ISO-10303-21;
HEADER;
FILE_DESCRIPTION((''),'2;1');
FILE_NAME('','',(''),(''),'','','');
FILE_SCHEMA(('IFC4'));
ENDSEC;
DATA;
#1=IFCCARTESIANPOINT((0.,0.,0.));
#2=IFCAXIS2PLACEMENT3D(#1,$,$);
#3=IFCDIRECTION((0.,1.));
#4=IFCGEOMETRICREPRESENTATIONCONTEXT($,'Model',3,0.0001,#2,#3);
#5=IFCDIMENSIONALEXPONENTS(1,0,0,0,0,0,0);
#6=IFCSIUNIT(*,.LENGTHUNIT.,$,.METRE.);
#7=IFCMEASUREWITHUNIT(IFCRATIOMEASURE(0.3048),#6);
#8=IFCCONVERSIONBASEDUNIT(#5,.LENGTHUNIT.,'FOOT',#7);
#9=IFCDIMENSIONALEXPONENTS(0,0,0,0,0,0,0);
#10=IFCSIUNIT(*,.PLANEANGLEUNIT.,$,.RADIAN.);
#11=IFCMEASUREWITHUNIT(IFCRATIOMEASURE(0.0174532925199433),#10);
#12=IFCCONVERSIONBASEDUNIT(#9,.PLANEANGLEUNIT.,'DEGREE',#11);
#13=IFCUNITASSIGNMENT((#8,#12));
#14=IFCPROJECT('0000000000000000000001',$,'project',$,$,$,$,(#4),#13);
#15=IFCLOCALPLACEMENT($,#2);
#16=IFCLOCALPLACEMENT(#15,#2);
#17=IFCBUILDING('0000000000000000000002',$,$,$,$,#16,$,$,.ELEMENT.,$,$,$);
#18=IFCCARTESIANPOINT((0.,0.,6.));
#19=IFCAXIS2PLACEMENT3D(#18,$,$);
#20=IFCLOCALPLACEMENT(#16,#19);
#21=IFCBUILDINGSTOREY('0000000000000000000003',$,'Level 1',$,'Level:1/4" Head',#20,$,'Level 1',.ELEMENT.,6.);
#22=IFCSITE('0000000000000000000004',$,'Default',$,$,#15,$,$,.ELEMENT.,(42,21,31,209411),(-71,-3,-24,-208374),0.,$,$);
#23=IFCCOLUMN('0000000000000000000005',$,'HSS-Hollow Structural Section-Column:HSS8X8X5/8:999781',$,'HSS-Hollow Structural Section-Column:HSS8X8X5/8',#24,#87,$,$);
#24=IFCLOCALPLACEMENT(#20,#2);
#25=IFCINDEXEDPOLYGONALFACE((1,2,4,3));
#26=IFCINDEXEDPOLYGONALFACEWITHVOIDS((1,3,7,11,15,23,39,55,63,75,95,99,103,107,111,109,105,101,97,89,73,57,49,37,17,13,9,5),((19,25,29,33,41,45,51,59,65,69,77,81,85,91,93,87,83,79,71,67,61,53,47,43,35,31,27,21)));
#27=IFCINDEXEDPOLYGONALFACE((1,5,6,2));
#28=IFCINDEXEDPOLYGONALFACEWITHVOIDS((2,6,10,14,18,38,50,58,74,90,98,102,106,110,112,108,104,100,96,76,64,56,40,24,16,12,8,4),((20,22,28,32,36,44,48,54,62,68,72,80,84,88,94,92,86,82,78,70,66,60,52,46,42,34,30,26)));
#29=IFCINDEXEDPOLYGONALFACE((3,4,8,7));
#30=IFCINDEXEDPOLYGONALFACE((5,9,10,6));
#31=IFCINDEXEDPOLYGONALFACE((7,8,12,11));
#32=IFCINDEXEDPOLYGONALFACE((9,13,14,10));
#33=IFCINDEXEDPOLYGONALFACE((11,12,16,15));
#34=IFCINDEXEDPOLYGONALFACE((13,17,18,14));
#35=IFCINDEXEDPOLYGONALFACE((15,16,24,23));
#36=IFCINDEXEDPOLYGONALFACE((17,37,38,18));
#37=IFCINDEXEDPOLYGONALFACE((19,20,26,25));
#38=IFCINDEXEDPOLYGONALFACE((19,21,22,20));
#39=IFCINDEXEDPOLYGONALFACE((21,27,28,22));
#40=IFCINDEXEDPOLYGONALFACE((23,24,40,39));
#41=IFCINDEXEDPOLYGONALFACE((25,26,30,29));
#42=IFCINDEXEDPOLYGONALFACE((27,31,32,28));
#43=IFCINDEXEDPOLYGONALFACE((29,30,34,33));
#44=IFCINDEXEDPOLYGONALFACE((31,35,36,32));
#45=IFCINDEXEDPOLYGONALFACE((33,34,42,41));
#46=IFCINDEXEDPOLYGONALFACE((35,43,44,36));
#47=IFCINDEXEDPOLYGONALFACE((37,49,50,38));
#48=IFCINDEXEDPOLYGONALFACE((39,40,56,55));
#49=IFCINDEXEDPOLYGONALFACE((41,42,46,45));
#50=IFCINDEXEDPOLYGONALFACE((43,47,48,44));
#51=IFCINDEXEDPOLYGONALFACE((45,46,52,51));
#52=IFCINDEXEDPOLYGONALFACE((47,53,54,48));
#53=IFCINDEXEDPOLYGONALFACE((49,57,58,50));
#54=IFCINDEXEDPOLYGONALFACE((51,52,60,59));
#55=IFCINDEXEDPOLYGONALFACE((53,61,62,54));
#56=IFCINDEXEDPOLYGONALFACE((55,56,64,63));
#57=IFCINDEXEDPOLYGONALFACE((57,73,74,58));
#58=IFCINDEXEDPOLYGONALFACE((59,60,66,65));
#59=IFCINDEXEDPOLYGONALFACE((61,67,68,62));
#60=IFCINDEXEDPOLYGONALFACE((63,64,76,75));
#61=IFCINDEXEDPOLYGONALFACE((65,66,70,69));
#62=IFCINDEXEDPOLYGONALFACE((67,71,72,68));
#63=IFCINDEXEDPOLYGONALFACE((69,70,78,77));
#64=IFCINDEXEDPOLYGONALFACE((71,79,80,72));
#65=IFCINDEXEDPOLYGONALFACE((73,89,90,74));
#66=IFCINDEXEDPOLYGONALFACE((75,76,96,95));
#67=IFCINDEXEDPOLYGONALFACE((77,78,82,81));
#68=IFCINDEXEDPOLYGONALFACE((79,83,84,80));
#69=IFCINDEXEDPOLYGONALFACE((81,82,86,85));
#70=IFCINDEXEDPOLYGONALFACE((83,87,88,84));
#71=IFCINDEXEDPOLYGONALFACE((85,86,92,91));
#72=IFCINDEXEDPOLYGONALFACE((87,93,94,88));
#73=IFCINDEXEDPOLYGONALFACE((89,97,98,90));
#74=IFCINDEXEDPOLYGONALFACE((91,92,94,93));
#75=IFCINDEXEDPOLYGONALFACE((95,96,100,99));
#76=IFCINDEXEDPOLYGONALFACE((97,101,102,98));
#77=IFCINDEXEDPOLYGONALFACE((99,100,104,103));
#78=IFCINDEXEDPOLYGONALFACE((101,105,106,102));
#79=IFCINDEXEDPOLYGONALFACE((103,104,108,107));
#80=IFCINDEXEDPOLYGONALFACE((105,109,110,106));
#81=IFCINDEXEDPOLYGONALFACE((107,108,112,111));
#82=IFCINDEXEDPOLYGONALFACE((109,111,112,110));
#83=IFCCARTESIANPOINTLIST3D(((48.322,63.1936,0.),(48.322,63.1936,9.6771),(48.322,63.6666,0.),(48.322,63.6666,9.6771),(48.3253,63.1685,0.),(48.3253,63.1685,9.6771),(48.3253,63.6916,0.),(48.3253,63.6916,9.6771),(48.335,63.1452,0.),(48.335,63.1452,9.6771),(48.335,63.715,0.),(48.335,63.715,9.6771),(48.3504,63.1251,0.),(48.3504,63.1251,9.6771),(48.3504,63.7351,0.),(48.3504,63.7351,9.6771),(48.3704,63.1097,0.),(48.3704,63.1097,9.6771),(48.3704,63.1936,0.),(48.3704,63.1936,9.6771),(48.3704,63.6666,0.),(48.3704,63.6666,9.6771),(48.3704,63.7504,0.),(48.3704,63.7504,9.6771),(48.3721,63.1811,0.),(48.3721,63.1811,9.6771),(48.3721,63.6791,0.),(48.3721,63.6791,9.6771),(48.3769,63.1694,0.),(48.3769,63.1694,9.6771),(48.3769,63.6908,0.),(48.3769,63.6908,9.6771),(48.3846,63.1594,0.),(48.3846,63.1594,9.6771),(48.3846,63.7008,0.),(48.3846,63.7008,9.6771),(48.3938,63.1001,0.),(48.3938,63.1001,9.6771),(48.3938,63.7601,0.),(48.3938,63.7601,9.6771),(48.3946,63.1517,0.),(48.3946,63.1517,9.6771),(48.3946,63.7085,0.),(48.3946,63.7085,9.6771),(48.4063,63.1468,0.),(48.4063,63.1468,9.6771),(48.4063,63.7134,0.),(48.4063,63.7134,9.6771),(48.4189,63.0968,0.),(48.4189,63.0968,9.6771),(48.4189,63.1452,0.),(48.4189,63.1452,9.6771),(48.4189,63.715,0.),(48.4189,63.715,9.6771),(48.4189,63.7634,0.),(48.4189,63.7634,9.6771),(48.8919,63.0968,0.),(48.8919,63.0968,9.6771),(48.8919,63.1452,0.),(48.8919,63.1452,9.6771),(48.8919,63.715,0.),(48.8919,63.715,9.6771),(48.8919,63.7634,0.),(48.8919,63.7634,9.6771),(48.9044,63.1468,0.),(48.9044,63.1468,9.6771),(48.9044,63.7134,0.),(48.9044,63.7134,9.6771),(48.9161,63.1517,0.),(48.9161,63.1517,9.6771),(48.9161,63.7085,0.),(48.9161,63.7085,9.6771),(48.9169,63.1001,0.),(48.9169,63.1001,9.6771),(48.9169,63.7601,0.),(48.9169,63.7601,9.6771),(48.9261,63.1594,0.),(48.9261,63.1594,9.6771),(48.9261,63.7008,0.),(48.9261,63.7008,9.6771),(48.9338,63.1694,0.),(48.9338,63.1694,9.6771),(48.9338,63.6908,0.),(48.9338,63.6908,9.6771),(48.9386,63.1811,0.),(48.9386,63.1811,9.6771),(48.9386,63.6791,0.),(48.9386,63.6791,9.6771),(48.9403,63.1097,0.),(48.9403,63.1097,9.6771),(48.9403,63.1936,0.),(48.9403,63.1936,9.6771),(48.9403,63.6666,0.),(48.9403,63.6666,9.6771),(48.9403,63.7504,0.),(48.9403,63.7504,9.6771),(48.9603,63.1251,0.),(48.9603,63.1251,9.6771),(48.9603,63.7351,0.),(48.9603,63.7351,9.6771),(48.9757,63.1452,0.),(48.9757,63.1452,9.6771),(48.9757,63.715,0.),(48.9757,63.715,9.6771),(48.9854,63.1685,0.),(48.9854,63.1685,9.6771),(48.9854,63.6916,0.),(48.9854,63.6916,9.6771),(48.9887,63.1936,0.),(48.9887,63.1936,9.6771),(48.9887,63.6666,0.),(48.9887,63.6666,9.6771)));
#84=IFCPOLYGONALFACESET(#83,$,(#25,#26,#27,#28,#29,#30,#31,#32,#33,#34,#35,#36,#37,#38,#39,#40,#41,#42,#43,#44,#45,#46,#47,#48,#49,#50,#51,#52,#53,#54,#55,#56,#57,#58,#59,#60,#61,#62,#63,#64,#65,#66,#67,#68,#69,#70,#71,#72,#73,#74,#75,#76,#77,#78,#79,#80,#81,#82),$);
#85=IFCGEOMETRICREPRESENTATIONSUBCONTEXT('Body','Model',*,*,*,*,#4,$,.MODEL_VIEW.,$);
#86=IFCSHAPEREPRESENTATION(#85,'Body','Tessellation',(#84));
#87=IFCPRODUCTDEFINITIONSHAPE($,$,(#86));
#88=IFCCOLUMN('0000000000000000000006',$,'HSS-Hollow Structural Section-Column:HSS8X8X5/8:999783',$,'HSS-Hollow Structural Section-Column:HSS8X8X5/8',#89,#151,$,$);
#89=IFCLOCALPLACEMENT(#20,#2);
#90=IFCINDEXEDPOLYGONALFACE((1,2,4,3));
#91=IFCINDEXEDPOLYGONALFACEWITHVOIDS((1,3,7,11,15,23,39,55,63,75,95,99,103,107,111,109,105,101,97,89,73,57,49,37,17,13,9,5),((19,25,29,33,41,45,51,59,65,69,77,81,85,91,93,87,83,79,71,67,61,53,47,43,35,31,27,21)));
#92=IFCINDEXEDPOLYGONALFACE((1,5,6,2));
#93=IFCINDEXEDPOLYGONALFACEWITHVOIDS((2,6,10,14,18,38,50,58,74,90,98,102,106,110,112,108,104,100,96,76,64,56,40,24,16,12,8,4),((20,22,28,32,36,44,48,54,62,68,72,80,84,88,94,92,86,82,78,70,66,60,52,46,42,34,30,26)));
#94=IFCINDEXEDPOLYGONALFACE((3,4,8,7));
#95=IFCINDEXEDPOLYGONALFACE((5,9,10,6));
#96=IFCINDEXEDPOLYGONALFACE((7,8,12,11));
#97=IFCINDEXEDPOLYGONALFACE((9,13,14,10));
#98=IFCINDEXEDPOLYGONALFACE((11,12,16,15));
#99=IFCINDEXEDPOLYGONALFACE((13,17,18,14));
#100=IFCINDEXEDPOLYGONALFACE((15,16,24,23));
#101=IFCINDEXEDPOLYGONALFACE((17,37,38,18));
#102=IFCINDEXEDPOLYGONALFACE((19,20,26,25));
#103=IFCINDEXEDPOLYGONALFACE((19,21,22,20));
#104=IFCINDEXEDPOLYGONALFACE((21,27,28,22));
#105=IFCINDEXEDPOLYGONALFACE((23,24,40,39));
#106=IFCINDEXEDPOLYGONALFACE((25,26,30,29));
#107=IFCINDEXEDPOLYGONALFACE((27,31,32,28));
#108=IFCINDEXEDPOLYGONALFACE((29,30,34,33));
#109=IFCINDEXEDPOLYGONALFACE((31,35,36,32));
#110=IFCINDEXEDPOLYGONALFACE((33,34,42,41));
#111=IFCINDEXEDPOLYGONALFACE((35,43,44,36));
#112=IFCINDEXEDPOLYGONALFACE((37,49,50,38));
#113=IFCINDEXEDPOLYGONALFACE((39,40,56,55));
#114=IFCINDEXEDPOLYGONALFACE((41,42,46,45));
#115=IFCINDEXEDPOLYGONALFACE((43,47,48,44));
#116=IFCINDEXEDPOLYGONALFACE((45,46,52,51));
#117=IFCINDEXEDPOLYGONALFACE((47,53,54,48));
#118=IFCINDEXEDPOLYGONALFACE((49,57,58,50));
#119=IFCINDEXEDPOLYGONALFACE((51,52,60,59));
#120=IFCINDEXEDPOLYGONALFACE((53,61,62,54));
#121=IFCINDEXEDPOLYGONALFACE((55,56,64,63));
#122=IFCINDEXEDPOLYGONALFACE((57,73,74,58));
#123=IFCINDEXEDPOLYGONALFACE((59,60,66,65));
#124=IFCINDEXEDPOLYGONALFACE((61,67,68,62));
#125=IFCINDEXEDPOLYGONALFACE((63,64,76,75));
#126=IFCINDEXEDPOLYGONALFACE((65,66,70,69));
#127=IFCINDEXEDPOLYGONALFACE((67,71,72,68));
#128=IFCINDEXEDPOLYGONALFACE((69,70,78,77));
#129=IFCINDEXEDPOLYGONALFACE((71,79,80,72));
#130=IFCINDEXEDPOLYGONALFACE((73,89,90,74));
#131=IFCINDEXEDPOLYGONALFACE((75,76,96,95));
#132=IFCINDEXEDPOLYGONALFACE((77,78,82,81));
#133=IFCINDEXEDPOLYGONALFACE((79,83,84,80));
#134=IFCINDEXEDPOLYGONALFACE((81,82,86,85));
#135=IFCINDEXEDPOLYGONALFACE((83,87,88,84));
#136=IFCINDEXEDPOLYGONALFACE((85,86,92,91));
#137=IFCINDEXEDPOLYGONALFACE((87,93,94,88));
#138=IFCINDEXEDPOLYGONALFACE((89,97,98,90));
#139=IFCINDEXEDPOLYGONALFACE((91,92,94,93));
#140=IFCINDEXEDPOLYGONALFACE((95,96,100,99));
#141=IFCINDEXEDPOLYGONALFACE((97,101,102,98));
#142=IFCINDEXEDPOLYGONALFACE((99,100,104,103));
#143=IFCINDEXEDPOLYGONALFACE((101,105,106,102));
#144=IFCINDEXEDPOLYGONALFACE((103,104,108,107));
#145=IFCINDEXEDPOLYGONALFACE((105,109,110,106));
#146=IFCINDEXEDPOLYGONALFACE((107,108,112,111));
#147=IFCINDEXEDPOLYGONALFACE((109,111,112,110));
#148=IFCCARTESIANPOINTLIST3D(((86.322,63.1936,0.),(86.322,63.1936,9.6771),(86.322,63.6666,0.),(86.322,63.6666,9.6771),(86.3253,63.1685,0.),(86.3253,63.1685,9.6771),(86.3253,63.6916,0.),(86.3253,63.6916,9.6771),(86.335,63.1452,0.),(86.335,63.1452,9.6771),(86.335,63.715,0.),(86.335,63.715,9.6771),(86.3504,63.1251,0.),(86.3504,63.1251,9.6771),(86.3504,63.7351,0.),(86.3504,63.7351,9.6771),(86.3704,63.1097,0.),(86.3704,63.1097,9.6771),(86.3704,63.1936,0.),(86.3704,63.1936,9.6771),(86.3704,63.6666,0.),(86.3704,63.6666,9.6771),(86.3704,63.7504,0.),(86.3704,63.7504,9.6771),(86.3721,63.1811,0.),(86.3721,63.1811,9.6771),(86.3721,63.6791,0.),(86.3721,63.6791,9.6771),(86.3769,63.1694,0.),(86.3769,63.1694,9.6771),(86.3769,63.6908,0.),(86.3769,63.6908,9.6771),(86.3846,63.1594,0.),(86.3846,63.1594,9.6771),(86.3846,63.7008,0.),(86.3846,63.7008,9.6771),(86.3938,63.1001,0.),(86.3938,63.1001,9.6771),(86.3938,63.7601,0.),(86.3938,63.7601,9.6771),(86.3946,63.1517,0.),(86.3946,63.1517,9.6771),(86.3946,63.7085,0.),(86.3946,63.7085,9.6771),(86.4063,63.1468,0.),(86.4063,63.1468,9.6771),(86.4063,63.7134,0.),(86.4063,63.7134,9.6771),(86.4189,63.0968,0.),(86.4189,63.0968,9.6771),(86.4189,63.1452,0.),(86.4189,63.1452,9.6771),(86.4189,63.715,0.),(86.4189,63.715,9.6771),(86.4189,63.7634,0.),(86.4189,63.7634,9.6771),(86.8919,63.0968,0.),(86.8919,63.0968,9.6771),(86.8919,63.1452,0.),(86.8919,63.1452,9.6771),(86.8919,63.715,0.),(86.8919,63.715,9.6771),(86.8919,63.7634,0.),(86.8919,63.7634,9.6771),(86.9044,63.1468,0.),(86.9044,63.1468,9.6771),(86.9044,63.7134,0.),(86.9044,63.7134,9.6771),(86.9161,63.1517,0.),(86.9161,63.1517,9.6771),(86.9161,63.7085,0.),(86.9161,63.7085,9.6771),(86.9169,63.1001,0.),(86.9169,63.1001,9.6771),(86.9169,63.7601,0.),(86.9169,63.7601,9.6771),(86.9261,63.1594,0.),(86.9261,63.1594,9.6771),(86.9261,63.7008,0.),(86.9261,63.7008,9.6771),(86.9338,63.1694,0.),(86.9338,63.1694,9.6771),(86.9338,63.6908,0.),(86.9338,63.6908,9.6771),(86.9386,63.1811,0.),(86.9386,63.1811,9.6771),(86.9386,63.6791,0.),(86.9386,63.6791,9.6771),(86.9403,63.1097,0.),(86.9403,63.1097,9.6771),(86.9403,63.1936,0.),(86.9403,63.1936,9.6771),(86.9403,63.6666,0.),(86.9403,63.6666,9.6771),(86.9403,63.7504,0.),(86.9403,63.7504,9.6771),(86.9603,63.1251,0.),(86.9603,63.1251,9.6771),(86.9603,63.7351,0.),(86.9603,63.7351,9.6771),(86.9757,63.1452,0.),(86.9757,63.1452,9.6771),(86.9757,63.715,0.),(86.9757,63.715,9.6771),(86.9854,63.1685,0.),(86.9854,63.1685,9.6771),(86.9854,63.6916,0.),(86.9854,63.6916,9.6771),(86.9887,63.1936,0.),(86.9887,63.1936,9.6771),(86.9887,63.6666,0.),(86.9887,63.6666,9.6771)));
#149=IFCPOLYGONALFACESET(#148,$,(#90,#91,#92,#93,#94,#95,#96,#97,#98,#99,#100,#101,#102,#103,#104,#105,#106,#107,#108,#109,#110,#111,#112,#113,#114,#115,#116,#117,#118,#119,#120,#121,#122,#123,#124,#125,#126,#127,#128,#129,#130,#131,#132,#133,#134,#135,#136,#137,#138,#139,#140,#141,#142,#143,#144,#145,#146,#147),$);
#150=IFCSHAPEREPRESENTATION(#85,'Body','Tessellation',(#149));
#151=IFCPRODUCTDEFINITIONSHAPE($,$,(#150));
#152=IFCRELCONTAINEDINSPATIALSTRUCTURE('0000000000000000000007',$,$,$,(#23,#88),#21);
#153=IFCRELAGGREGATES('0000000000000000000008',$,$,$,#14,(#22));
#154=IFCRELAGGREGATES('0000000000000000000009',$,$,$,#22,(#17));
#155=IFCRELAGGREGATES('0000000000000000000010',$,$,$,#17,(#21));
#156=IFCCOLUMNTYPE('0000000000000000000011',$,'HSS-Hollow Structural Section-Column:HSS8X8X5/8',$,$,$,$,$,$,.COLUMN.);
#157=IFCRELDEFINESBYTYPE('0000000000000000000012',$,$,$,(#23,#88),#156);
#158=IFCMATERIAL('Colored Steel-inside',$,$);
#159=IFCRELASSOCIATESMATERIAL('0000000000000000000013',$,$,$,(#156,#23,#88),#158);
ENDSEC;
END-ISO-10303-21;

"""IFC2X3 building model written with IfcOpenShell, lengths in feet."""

from ifc_helpers import new_model, entity, si_unit, converted_unit, direction, frame, frame_2d, origin, place, context, subcontext, project, spatial, polyline, circle_curve, parameter, trimmed, segment, composite_curve, outline, extrude, source, transform, mapped, material, type_object, type_shapes, element, save


model = new_model("IFC2X3")

# Units and contexts
model_context = context("Model", 3, precision=0.0001, world=origin(), true_north=direction((0.0, 1.0)))
body_context = subcontext(model_context, "Body", "Model", "MODEL_VIEW")
ifc_project = project(units=[converted_unit("LENGTHUNIT", "FOOT", entity("IfcRatioMeasure", 0.3048), si_unit("LENGTHUNIT", "METRE"), dimensions=[1, 0, 0, 0, 0, 0, 0]), converted_unit("PLANEANGLEUNIT", "DEGREE", entity("IfcRatioMeasure", 0.0174532925199433), si_unit("PLANEANGLEUNIT", "RADIAN"), dimensions=[0, 0, 0, 0, 0, 0, 0])], contexts=[model_context])

# Site, building, storey
site_placement = place(None, origin())
site = spatial("IfcSite", under=ifc_project, at=site_placement, Name="Default", CompositionType="ELEMENT", RefLatitude=(42, 21, 31, 209411), RefLongitude=(-71, -3, -24, -208374), RefElevation=0.0)
building_placement = place(site_placement, origin())
building = spatial("IfcBuilding", under=site, at=building_placement, CompositionType="ELEMENT")
storey_placement = place(building_placement, frame((0.0, 0.0, 6.0)))
storey = spatial("IfcBuildingStorey", under=building, at=storey_placement, Name="Level 1", ObjectType="Level:1/4\" Head", LongName="Level 1", CompositionType="ELEMENT", Elevation=6.0)

# Columns
ifc_material_1 = material(Name="Colored Steel-inside")
column_type_1 = type_object("IfcColumnType", Name="HSS-Hollow Structural Section-Column:HSS8X8X5/8", PredefinedType="COLUMN", material=ifc_material_1)
shared_shape_1 = source(origin(), body_context, "Body", "SweptSolid", [
    extrude(outline(composite_curve([segment(polyline([(-0.2365, -0.3333), (0.2365, -0.3333)]), True, "CONTINUOUS"), segment(trimmed(circle_curve(frame_2d((0.2365, -0.2365), x_axis=(-1.0, 0.0)), 0.0968), [parameter(90.0)], [parameter(180.0)], True, "PARAMETER"), True, "CONTINUOUS"), segment(polyline([(0.3333, -0.2365), (0.3333, 0.2365)]), True, "CONTINUOUS"), segment(trimmed(circle_curve(frame_2d((0.2365, 0.2365), x_axis=(-1.0, 0.0)), 0.0968), [parameter(180.0)], [parameter(270.0)], True, "PARAMETER"), True, "CONTINUOUS"), segment(polyline([(0.2365, 0.3333), (-0.2365, 0.3333)]), True, "CONTINUOUS"), segment(trimmed(circle_curve(frame_2d((-0.2365, 0.2365), x_axis=(-1.0, 0.0)), 0.0968), [parameter(270.0)], [parameter(360.0)], True, "PARAMETER"), True, "CONTINUOUS"), segment(polyline([(-0.3333, 0.2365), (-0.3333, -0.2365)]), True, "CONTINUOUS"), segment(trimmed(circle_curve(frame_2d((-0.2365, -0.2365), x_axis=(-1.0, 0.0)), 0.0968), [parameter(360.0)], [parameter(90.0)], True, "PARAMETER"), True, "CONTINUOUS")], self_intersect=False), holes=[composite_curve([segment(trimmed(circle_curve(frame_2d((-0.2365, -0.2365), x_axis=(-1.0, 0.0)), 0.0484), [parameter(0.0)], [parameter(90.0)], True, "PARAMETER"), False, "CONTINUOUS"), segment(polyline([(-0.2849, -0.2365), (-0.2849, 0.2365)]), True, "CONTINUOUS"), segment(trimmed(circle_curve(frame_2d((-0.2365, 0.2365), x_axis=(-1.0, 0.0)), 0.0484), [parameter(270.0)], [parameter(360.0)], True, "PARAMETER"), False, "CONTINUOUS"), segment(polyline([(-0.2365, 0.2849), (0.2365, 0.2849)]), True, "CONTINUOUS"), segment(trimmed(circle_curve(frame_2d((0.2365, 0.2365), x_axis=(-1.0, 0.0)), 0.0484), [parameter(180.0)], [parameter(270.0)], True, "PARAMETER"), False, "CONTINUOUS"), segment(polyline([(0.2849, 0.2365), (0.2849, -0.2365)]), True, "CONTINUOUS"), segment(trimmed(circle_curve(frame_2d((0.2365, -0.2365), x_axis=(-1.0, 0.0)), 0.0484), [parameter(90.0)], [parameter(180.0)], True, "PARAMETER"), False, "CONTINUOUS"), segment(polyline([(0.2365, -0.2849), (-0.2365, -0.2849)]), True, "CONTINUOUS")], self_intersect=False)]), frame((0.0, 0.0, 6.0), z_axis=(0.0, 0.0, 1.0), x_axis=(-1.0, 0.0, 0.0)), (0.0, 0.0, 1.0), 9.6771),
])
type_shapes(column_type_1, [shared_shape_1])
for number, where, z_axis, x_axis, name in (
    (1, (48.6554, 63.4301, -6.0), (0.0, 0.0, 1.0), (-1.0, 0.0, 0.0), "HSS-Hollow Structural Section-Column:HSS8X8X5/8:999781"),
    (2, (86.6554, 63.4301, -6.0), (0.0, 0.0, 1.0), (-1.0, 0.0, 0.0), "HSS-Hollow Structural Section-Column:HSS8X8X5/8:999783"),
):
    element("IfcColumn", number, at=place(storey_placement, frame(where, z_axis=z_axis, x_axis=x_axis)), inside=storey, type_object=column_type_1, material=ifc_material_1, Name=name, ObjectType="HSS-Hollow Structural Section-Column:HSS8X8X5/8", context=body_context, shape_type="MappedRepresentation", body=[
        mapped(shared_shape_1, transform((0.0, 0.0, 0.0), scale=1.0)),
    ])

save(model, "model.ifc")
